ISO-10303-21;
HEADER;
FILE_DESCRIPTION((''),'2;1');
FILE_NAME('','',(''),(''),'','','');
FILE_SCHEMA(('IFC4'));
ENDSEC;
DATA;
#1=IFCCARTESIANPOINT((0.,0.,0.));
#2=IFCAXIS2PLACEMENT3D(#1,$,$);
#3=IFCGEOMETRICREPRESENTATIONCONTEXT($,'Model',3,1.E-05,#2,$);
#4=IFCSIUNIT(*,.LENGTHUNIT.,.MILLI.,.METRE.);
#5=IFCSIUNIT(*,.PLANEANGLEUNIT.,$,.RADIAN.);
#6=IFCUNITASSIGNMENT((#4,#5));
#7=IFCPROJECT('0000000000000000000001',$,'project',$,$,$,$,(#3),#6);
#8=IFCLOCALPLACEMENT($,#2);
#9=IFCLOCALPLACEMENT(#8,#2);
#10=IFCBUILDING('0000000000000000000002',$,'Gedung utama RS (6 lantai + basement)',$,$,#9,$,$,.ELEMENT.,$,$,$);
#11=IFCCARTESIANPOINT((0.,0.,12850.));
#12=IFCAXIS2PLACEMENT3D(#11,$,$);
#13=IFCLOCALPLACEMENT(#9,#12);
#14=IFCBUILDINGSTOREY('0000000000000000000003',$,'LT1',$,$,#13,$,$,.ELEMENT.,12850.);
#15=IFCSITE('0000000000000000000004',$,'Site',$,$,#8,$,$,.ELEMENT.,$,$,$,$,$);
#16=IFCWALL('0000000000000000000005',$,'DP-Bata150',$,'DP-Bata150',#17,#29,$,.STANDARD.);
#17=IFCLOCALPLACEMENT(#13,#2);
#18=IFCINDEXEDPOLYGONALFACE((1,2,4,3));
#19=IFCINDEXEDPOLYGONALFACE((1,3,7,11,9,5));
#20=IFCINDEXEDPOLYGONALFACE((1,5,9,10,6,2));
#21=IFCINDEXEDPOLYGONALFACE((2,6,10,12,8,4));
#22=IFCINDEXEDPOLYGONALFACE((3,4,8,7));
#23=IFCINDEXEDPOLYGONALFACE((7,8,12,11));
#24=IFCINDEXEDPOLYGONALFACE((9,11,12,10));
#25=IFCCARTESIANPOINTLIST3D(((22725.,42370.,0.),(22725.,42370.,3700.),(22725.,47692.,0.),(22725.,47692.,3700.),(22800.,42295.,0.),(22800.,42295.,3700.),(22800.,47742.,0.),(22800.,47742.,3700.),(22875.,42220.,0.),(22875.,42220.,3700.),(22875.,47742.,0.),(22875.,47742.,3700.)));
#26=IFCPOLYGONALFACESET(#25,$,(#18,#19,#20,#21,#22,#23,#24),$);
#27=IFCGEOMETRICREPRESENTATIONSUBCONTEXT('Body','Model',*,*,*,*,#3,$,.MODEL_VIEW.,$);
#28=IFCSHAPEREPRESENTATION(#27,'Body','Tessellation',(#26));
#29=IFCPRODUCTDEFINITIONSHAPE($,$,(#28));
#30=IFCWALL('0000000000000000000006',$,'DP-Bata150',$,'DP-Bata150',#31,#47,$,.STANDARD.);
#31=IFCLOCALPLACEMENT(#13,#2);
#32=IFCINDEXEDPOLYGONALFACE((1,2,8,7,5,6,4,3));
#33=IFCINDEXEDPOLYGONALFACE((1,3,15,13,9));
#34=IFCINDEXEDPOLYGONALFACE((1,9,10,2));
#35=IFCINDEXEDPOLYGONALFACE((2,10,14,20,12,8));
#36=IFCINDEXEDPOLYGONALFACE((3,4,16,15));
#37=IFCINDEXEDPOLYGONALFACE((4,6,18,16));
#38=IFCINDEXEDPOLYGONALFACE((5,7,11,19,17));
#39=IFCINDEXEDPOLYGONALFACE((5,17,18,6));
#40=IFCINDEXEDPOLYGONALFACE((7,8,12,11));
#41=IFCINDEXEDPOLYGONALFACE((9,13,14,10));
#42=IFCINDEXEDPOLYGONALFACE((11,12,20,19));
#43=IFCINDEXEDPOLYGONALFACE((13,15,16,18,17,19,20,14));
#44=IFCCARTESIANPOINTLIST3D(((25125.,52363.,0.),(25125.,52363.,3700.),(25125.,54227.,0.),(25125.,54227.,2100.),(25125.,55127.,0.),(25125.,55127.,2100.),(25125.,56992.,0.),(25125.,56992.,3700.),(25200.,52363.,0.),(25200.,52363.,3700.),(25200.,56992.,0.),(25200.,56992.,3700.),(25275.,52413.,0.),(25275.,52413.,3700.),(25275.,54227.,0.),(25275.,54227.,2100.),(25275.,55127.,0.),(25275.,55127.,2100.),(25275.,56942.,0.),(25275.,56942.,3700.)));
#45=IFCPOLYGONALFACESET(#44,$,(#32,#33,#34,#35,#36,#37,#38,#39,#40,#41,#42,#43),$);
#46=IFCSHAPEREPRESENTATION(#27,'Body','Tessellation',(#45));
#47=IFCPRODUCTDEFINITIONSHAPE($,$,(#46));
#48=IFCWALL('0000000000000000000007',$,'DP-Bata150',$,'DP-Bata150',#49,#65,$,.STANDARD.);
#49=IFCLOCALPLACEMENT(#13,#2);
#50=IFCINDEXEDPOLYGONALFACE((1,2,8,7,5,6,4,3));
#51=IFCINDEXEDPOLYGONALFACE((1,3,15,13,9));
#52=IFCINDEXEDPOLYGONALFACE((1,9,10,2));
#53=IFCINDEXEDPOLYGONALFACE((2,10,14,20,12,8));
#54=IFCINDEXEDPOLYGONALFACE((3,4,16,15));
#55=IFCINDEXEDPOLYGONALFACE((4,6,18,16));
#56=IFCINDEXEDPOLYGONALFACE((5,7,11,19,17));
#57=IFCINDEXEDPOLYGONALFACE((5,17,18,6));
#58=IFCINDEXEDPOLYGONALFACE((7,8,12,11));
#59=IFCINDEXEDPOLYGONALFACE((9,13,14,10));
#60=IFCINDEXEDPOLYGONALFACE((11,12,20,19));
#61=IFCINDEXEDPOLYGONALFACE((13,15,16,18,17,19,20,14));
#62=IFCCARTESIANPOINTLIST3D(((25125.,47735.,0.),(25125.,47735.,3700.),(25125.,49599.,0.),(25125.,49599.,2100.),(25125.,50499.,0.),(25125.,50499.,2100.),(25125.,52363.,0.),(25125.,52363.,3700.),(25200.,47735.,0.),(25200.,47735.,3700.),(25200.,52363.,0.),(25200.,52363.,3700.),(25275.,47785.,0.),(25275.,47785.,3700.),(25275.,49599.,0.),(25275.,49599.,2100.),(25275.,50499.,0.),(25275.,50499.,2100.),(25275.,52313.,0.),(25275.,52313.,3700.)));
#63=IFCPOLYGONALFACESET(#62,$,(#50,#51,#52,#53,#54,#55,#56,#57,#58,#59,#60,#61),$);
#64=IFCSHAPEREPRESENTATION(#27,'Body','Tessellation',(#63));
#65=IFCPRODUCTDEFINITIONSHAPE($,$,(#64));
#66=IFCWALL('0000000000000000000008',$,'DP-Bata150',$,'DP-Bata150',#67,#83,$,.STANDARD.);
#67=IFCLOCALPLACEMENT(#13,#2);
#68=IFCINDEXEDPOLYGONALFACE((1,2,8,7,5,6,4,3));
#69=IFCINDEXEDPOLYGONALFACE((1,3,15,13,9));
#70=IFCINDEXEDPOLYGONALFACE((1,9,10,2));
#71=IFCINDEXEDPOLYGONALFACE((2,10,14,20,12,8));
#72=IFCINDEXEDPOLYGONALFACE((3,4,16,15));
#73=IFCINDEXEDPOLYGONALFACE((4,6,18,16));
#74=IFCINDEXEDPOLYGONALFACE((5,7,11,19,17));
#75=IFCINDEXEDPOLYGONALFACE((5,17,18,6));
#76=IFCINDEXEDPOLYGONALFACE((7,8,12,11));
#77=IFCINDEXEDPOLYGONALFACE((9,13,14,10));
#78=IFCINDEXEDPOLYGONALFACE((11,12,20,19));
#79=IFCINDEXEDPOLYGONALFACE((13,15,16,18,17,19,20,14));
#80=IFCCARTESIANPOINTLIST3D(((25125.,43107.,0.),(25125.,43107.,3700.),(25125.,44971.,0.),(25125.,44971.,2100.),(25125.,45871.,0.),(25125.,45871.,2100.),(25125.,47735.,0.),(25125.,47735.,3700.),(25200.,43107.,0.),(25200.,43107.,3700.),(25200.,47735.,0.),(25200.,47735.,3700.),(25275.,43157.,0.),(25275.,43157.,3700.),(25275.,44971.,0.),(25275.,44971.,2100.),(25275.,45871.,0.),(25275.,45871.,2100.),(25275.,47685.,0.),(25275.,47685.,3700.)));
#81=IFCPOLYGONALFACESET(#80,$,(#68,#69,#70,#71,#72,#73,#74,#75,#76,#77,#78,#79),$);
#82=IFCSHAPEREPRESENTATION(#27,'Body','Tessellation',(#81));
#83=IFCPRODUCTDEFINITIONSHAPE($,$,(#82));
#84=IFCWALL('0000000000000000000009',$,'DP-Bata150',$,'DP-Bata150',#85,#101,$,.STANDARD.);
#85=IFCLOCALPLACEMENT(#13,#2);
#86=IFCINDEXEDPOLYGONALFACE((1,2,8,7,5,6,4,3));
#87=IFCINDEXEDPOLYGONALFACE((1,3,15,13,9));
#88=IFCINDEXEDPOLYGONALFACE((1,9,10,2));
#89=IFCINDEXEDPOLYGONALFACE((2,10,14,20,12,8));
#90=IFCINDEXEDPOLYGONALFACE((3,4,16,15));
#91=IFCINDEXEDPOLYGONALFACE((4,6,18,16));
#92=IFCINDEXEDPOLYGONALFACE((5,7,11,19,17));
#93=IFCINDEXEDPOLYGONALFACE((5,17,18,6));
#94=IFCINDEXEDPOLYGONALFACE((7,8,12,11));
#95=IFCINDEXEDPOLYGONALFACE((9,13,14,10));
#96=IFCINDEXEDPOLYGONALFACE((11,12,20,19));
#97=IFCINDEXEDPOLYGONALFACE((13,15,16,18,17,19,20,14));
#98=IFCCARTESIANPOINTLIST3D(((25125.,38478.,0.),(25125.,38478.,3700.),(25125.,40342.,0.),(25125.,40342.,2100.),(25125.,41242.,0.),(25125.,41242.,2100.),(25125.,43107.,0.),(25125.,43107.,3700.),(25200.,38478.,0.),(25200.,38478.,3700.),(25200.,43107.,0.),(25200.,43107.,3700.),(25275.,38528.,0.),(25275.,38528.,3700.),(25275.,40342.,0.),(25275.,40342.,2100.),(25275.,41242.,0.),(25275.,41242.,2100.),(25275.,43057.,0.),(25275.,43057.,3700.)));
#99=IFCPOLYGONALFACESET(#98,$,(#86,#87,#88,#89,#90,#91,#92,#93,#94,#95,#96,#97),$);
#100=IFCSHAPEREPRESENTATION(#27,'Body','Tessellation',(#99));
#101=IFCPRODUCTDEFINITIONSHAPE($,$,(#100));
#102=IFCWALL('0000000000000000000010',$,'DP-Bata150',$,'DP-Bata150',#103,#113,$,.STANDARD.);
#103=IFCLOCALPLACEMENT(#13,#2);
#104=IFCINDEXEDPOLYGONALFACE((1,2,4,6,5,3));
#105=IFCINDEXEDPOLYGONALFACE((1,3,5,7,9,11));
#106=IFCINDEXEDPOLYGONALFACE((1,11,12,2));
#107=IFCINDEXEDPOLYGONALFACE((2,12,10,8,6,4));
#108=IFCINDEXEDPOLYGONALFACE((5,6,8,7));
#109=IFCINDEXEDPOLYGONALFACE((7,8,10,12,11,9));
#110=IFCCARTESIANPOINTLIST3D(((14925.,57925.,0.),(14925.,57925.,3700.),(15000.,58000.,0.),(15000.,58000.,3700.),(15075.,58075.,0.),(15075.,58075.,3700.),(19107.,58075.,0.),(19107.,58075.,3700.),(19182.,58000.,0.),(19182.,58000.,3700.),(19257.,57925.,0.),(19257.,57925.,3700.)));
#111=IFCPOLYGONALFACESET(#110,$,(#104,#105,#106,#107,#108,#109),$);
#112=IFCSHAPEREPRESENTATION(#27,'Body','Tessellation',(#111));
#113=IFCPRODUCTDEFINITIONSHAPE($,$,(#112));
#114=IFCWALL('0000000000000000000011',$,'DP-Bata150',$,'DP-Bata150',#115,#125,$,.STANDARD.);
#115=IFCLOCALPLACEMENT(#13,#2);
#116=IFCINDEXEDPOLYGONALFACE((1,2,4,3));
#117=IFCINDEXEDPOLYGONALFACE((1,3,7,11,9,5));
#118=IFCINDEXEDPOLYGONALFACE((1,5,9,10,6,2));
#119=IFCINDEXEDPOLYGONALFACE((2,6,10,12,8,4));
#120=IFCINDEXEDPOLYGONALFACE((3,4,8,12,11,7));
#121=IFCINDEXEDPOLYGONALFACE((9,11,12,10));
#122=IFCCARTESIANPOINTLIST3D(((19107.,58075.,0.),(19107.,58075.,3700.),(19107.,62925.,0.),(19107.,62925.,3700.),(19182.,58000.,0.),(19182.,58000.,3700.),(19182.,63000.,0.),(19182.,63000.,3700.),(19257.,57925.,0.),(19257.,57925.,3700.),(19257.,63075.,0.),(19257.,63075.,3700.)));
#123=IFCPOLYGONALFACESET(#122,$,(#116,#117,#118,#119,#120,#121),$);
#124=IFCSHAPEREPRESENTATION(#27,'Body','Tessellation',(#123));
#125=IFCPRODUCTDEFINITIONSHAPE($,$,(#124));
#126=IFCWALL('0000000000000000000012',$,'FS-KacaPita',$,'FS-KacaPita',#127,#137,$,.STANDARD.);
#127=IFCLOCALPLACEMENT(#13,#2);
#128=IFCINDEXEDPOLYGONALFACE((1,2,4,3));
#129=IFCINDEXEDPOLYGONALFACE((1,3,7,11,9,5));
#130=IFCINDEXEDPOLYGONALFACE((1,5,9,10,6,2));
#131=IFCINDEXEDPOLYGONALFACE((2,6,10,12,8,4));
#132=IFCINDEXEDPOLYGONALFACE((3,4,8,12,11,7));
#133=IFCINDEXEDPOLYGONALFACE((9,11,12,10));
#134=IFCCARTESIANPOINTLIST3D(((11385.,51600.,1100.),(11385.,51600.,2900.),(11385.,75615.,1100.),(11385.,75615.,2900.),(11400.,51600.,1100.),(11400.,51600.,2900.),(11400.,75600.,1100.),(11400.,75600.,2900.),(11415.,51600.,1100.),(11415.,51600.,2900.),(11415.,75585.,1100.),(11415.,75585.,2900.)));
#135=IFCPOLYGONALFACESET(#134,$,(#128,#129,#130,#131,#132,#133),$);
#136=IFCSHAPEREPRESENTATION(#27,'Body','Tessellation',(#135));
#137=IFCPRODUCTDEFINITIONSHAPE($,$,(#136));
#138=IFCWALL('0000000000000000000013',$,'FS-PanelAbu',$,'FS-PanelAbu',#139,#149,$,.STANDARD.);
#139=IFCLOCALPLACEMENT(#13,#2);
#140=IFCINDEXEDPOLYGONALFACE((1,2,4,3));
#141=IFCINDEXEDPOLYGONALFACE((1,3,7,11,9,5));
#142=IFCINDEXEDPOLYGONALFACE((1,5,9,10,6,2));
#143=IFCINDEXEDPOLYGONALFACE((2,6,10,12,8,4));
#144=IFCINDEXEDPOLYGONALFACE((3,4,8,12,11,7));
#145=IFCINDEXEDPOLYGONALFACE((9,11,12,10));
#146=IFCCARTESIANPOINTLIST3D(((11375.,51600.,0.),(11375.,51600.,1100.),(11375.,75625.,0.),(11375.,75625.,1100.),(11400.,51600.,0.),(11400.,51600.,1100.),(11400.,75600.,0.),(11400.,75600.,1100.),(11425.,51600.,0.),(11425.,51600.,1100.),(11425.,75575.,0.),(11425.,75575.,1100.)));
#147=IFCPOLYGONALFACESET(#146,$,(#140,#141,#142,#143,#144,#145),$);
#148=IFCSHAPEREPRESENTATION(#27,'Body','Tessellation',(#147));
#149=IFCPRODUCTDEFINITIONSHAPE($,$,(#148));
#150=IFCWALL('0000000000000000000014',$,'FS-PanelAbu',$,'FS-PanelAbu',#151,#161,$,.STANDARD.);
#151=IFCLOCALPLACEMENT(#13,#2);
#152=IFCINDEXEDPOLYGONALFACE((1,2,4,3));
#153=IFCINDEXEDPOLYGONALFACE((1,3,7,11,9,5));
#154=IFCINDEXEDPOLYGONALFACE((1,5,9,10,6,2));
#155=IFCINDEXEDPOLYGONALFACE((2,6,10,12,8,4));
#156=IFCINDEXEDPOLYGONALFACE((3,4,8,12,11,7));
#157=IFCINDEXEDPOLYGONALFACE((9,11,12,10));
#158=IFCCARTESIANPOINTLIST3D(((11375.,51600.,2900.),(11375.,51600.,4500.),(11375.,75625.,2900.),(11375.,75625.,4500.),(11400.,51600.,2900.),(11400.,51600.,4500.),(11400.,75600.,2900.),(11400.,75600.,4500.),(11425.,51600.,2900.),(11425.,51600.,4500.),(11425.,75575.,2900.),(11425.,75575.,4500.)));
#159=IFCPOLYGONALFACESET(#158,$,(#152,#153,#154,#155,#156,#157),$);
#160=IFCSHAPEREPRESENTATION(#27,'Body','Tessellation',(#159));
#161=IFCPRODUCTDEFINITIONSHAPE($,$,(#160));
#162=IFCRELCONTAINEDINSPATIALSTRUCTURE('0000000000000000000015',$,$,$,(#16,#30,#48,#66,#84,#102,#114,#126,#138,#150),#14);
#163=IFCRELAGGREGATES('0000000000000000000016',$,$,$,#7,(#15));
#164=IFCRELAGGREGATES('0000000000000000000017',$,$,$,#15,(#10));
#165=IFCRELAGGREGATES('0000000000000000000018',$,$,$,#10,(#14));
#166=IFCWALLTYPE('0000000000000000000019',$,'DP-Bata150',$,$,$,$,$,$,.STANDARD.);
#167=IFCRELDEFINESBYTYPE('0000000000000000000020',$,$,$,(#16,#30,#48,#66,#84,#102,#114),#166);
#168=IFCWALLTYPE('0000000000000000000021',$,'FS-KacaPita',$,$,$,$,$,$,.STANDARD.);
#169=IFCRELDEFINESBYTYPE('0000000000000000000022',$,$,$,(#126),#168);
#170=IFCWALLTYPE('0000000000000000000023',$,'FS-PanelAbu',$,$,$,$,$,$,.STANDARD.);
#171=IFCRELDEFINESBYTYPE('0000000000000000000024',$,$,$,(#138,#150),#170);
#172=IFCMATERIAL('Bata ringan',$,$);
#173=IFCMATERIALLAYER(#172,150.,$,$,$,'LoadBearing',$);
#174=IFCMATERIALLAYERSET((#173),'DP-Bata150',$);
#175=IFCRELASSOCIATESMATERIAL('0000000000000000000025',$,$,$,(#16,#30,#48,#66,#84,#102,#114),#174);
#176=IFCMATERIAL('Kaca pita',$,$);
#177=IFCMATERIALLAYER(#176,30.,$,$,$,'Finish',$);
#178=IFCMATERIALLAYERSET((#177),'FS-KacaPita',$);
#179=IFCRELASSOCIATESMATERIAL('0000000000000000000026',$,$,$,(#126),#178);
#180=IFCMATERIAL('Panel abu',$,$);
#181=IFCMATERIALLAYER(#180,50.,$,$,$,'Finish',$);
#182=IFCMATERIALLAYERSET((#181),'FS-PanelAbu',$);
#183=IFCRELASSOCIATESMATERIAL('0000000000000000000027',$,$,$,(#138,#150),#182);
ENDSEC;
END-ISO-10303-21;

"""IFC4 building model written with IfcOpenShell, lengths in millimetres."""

from ifc_helpers import new_model, si_unit, frame, frame_2d, origin, place, context, subcontext, project, spatial, polyline, rectangle, outline, extrude, material, layer, layer_set, layer_usage, type_object, element, save


model = new_model("IFC4")

# Units and contexts
model_context = context("Model", 3, precision=1e-05, world=origin())
body_context = subcontext(model_context, "Body", "Model", "MODEL_VIEW")
ifc_project = project(units=[si_unit("LENGTHUNIT", "METRE", prefix="MILLI"), si_unit("PLANEANGLEUNIT", "RADIAN")], contexts=[model_context])

# Site, building, storey
site_placement = place(None, origin())
site = spatial("IfcSite", under=ifc_project, at=site_placement, Name="Site", CompositionType="ELEMENT")
building_placement = place(site_placement, origin())
building = spatial("IfcBuilding", under=site, at=building_placement, Name="Gedung utama RS (6 lantai + basement)", CompositionType="ELEMENT")
storey_placement = place(building_placement, frame((0.0, 0.0, 12850.0)))
storey = spatial("IfcBuildingStorey", under=building, at=storey_placement, Name="LT1", CompositionType="ELEMENT", Elevation=12850.0)

# Shared definitions
ifc_material_1 = material(Name="Bata ringan")

# Shared definitions
ifc_layer_1 = layer(ifc_material_1, 150.0, Category="LoadBearing")
ifc_layer_set_1 = layer_set([ifc_layer_1], Name="DP-Bata150")
ifc_layer_usage_1 = layer_usage(ifc_layer_set_1, "AXIS2", "NEGATIVE", 75.0)
wall_type_1 = type_object("IfcWallType", Name="DP-Bata150", PredefinedType="STANDARD")

# Wall
wall_1_placement = place(storey_placement, frame((22800.0, 47742.0, 0.0), z_axis=(0.0, 0.0, 1.0), x_axis=(0.0, -1.0, 0.0)))
element("IfcWall", 1, at=wall_1_placement, inside=storey, type_object=wall_type_1, material=ifc_layer_usage_1, Name="DP-Bata150", ObjectType="DP-Bata150", PredefinedType="STANDARD", context=body_context, shape_type="SweptSolid", body=[
    extrude(outline(polyline([(50.0, -75.0), (0.0, 0.0), (0.0, 75.0), (5522.0, 75.0), (5447.0, 0.0), (5372.0, -75.0), (50.0, -75.0)])), origin(), (0.0, 0.0, 1.0), 3700.0),
])

# Walls, openings
wall_2_placement = place(storey_placement, frame((25200.0, 56992.0, 0.0), z_axis=(0.0, 0.0, 1.0), x_axis=(0.0, -1.0, 0.0)))
wall_2 = element("IfcWall", 2, at=wall_2_placement, inside=storey, type_object=wall_type_1, material=ifc_layer_usage_1, Name="DP-Bata150", ObjectType="DP-Bata150", PredefinedType="STANDARD", context=body_context, shape_type="SweptSolid", body=[
    extrude(outline(polyline([(0.0, -75.0), (0.0, 0.0), (50.0, 75.0), (4579.0, 75.0), (4629.0, 0.0), (4629.0, -75.0), (0.0, -75.0)])), origin(), (0.0, 0.0, 1.0), 3700.0),
])
opening_1_placement = place(wall_2_placement, frame((1865.0, 0.0, 0.0), z_axis=(0.0, 0.0, 1.0), x_axis=(1.0, 0.0, 0.0)))
element("IfcOpeningElement", 3, at=opening_1_placement, cuts=wall_2, PredefinedType="OPENING", context=body_context, shape_type="SweptSolid", body=[
    extrude(rectangle(XDim=900.0, YDim=170.0, at=frame_2d((450.0, 0.0))), origin(), (0.0, 0.0, 1.0), 2100.0),
])
wall_3_placement = place(storey_placement, frame((25200.0, 52363.0, 0.0), z_axis=(0.0, 0.0, 1.0), x_axis=(0.0, -1.0, 0.0)))
wall_3 = element("IfcWall", 4, at=wall_3_placement, inside=storey, type_object=wall_type_1, material=ifc_layer_usage_1, Name="DP-Bata150", ObjectType="DP-Bata150", PredefinedType="STANDARD", context=body_context, shape_type="SweptSolid", body=[
    extrude(outline(polyline([(0.0, -75.0), (0.0, 0.0), (50.0, 75.0), (4578.0, 75.0), (4628.0, 0.0), (4628.0, -75.0), (0.0, -75.0)])), origin(), (0.0, 0.0, 1.0), 3700.0),
])
opening_2_placement = place(wall_3_placement, frame((1864.0, 0.0, 0.0), z_axis=(0.0, 0.0, 1.0), x_axis=(1.0, 0.0, 0.0)))
element("IfcOpeningElement", 5, at=opening_2_placement, cuts=wall_3, PredefinedType="OPENING", context=body_context, shape_type="SweptSolid", body=[
    extrude(rectangle(XDim=900.0, YDim=170.0, at=frame_2d((450.0, 0.0))), origin(), (0.0, 0.0, 1.0), 2100.0),
])
wall_4_placement = place(storey_placement, frame((25200.0, 47735.0, 0.0), z_axis=(0.0, 0.0, 1.0), x_axis=(0.0, -1.0, 0.0)))
wall_4 = element("IfcWall", 6, at=wall_4_placement, inside=storey, type_object=wall_type_1, material=ifc_layer_usage_1, Name="DP-Bata150", ObjectType="DP-Bata150", PredefinedType="STANDARD", context=body_context, shape_type="SweptSolid", body=[
    extrude(outline(polyline([(0.0, -75.0), (0.0, 0.0), (50.0, 75.0), (4578.0, 75.0), (4628.0, 0.0), (4628.0, -75.0), (0.0, -75.0)])), origin(), (0.0, 0.0, 1.0), 3700.0),
])
opening_3_placement = place(wall_4_placement, frame((1864.0, 0.0, 0.0), z_axis=(0.0, 0.0, 1.0), x_axis=(1.0, 0.0, 0.0)))
element("IfcOpeningElement", 7, at=opening_3_placement, cuts=wall_4, PredefinedType="OPENING", context=body_context, shape_type="SweptSolid", body=[
    extrude(rectangle(XDim=900.0, YDim=170.0, at=frame_2d((450.0, 0.0))), origin(), (0.0, 0.0, 1.0), 2100.0),
])
wall_5_placement = place(storey_placement, frame((25200.0, 43107.0, 0.0), z_axis=(0.0, 0.0, 1.0), x_axis=(0.0, -1.0, 0.0)))
wall_5 = element("IfcWall", 8, at=wall_5_placement, inside=storey, type_object=wall_type_1, material=ifc_layer_usage_1, Name="DP-Bata150", ObjectType="DP-Bata150", PredefinedType="STANDARD", context=body_context, shape_type="SweptSolid", body=[
    extrude(outline(polyline([(0.0, -75.0), (0.0, 0.0), (50.0, 75.0), (4579.0, 75.0), (4629.0, 0.0), (4629.0, -75.0), (0.0, -75.0)])), origin(), (0.0, 0.0, 1.0), 3700.0),
])
opening_4_placement = place(wall_5_placement, frame((1865.0, 0.0, 0.0), z_axis=(0.0, 0.0, 1.0), x_axis=(1.0, 0.0, 0.0)))
element("IfcOpeningElement", 9, at=opening_4_placement, cuts=wall_5, PredefinedType="OPENING", context=body_context, shape_type="SweptSolid", body=[
    extrude(rectangle(XDim=900.0, YDim=170.0, at=frame_2d((450.0, 0.0))), origin(), (0.0, 0.0, 1.0), 2100.0),
])

# Walls
wall_6_placement = place(storey_placement, frame((15000.0, 58000.0, 0.0), z_axis=(0.0, 0.0, 1.0), x_axis=(1.0, 0.0, 0.0)))
element("IfcWall", 10, at=wall_6_placement, inside=storey, type_object=wall_type_1, material=ifc_layer_usage_1, Name="DP-Bata150", ObjectType="DP-Bata150", PredefinedType="STANDARD", context=body_context, shape_type="SweptSolid", body=[
    extrude(outline(polyline([(-75.0, -75.0), (0.0, 0.0), (75.0, 75.0), (4107.0, 75.0), (4182.0, 0.0), (4257.0, -75.0), (-75.0, -75.0)])), origin(), (0.0, 0.0, 1.0), 3700.0),
])
wall_7_placement = place(storey_placement, frame((19182.0, 58000.0, 0.0), z_axis=(0.0, 0.0, 1.0), x_axis=(0.0, 1.0, 0.0)))
element("IfcWall", 11, at=wall_7_placement, inside=storey, type_object=wall_type_1, material=ifc_layer_usage_1, Name="DP-Bata150", ObjectType="DP-Bata150", PredefinedType="STANDARD", context=body_context, shape_type="SweptSolid", body=[
    extrude(outline(polyline([(-75.0, -75.0), (0.0, 0.0), (75.0, 75.0), (4925.0, 75.0), (5000.0, 0.0), (5075.0, -75.0), (-75.0, -75.0)])), origin(), (0.0, 0.0, 1.0), 3700.0),
])
ifc_material_2 = material(Name="Kaca pita")
ifc_layer_2 = layer(ifc_material_2, 30.0, Category="Finish")
ifc_layer_set_2 = layer_set([ifc_layer_2], Name="FS-KacaPita")
ifc_layer_usage_2 = layer_usage(ifc_layer_set_2, "AXIS2", "NEGATIVE", 15.0)
wall_type_2 = type_object("IfcWallType", Name="FS-KacaPita", PredefinedType="STANDARD")
wall_8_placement = place(storey_placement, frame((11400.0, 51600.0, 1100.0), z_axis=(0.0, 0.0, 1.0), x_axis=(0.0, 1.0, 0.0)))
element("IfcWall", 12, at=wall_8_placement, inside=storey, type_object=wall_type_2, material=ifc_layer_usage_2, Name="FS-KacaPita", ObjectType="FS-KacaPita", PredefinedType="STANDARD", context=body_context, shape_type="SweptSolid", body=[
    extrude(outline(polyline([(0.0, -15.0), (0.0, 0.0), (0.0, 15.0), (24015.0, 15.0), (24000.0, 0.0), (23985.0, -15.0), (0.0, -15.0)])), origin(), (0.0, 0.0, 1.0), 1800.0),
])
ifc_material_3 = material(Name="Panel abu")
ifc_layer_3 = layer(ifc_material_3, 50.0, Category="Finish")
ifc_layer_set_3 = layer_set([ifc_layer_3], Name="FS-PanelAbu")
ifc_layer_usage_3 = layer_usage(ifc_layer_set_3, "AXIS2", "NEGATIVE", 25.0)
wall_type_3 = type_object("IfcWallType", Name="FS-PanelAbu", PredefinedType="STANDARD")
wall_9_placement = place(storey_placement, frame((11400.0, 51600.0, 0.0), z_axis=(0.0, 0.0, 1.0), x_axis=(0.0, 1.0, 0.0)))
element("IfcWall", 13, at=wall_9_placement, inside=storey, type_object=wall_type_3, material=ifc_layer_usage_3, Name="FS-PanelAbu", ObjectType="FS-PanelAbu", PredefinedType="STANDARD", context=body_context, shape_type="SweptSolid", body=[
    extrude(outline(polyline([(0.0, -25.0), (0.0, 0.0), (0.0, 25.0), (24025.0, 25.0), (24000.0, 0.0), (23975.0, -25.0), (0.0, -25.0)])), origin(), (0.0, 0.0, 1.0), 1100.0),
])
wall_10_placement = place(storey_placement, frame((11400.0, 51600.0, 2900.0), z_axis=(0.0, 0.0, 1.0), x_axis=(0.0, 1.0, 0.0)))
element("IfcWall", 14, at=wall_10_placement, inside=storey, type_object=wall_type_3, material=ifc_layer_usage_3, Name="FS-PanelAbu", ObjectType="FS-PanelAbu", PredefinedType="STANDARD", context=body_context, shape_type="SweptSolid", body=[
    extrude(outline(polyline([(0.0, -25.0), (0.0, 0.0), (0.0, 25.0), (24025.0, 25.0), (24000.0, 0.0), (23975.0, -25.0), (0.0, -25.0)])), origin(), (0.0, 0.0, 1.0), 1600.0),
])

save(model, "model.ifc")
